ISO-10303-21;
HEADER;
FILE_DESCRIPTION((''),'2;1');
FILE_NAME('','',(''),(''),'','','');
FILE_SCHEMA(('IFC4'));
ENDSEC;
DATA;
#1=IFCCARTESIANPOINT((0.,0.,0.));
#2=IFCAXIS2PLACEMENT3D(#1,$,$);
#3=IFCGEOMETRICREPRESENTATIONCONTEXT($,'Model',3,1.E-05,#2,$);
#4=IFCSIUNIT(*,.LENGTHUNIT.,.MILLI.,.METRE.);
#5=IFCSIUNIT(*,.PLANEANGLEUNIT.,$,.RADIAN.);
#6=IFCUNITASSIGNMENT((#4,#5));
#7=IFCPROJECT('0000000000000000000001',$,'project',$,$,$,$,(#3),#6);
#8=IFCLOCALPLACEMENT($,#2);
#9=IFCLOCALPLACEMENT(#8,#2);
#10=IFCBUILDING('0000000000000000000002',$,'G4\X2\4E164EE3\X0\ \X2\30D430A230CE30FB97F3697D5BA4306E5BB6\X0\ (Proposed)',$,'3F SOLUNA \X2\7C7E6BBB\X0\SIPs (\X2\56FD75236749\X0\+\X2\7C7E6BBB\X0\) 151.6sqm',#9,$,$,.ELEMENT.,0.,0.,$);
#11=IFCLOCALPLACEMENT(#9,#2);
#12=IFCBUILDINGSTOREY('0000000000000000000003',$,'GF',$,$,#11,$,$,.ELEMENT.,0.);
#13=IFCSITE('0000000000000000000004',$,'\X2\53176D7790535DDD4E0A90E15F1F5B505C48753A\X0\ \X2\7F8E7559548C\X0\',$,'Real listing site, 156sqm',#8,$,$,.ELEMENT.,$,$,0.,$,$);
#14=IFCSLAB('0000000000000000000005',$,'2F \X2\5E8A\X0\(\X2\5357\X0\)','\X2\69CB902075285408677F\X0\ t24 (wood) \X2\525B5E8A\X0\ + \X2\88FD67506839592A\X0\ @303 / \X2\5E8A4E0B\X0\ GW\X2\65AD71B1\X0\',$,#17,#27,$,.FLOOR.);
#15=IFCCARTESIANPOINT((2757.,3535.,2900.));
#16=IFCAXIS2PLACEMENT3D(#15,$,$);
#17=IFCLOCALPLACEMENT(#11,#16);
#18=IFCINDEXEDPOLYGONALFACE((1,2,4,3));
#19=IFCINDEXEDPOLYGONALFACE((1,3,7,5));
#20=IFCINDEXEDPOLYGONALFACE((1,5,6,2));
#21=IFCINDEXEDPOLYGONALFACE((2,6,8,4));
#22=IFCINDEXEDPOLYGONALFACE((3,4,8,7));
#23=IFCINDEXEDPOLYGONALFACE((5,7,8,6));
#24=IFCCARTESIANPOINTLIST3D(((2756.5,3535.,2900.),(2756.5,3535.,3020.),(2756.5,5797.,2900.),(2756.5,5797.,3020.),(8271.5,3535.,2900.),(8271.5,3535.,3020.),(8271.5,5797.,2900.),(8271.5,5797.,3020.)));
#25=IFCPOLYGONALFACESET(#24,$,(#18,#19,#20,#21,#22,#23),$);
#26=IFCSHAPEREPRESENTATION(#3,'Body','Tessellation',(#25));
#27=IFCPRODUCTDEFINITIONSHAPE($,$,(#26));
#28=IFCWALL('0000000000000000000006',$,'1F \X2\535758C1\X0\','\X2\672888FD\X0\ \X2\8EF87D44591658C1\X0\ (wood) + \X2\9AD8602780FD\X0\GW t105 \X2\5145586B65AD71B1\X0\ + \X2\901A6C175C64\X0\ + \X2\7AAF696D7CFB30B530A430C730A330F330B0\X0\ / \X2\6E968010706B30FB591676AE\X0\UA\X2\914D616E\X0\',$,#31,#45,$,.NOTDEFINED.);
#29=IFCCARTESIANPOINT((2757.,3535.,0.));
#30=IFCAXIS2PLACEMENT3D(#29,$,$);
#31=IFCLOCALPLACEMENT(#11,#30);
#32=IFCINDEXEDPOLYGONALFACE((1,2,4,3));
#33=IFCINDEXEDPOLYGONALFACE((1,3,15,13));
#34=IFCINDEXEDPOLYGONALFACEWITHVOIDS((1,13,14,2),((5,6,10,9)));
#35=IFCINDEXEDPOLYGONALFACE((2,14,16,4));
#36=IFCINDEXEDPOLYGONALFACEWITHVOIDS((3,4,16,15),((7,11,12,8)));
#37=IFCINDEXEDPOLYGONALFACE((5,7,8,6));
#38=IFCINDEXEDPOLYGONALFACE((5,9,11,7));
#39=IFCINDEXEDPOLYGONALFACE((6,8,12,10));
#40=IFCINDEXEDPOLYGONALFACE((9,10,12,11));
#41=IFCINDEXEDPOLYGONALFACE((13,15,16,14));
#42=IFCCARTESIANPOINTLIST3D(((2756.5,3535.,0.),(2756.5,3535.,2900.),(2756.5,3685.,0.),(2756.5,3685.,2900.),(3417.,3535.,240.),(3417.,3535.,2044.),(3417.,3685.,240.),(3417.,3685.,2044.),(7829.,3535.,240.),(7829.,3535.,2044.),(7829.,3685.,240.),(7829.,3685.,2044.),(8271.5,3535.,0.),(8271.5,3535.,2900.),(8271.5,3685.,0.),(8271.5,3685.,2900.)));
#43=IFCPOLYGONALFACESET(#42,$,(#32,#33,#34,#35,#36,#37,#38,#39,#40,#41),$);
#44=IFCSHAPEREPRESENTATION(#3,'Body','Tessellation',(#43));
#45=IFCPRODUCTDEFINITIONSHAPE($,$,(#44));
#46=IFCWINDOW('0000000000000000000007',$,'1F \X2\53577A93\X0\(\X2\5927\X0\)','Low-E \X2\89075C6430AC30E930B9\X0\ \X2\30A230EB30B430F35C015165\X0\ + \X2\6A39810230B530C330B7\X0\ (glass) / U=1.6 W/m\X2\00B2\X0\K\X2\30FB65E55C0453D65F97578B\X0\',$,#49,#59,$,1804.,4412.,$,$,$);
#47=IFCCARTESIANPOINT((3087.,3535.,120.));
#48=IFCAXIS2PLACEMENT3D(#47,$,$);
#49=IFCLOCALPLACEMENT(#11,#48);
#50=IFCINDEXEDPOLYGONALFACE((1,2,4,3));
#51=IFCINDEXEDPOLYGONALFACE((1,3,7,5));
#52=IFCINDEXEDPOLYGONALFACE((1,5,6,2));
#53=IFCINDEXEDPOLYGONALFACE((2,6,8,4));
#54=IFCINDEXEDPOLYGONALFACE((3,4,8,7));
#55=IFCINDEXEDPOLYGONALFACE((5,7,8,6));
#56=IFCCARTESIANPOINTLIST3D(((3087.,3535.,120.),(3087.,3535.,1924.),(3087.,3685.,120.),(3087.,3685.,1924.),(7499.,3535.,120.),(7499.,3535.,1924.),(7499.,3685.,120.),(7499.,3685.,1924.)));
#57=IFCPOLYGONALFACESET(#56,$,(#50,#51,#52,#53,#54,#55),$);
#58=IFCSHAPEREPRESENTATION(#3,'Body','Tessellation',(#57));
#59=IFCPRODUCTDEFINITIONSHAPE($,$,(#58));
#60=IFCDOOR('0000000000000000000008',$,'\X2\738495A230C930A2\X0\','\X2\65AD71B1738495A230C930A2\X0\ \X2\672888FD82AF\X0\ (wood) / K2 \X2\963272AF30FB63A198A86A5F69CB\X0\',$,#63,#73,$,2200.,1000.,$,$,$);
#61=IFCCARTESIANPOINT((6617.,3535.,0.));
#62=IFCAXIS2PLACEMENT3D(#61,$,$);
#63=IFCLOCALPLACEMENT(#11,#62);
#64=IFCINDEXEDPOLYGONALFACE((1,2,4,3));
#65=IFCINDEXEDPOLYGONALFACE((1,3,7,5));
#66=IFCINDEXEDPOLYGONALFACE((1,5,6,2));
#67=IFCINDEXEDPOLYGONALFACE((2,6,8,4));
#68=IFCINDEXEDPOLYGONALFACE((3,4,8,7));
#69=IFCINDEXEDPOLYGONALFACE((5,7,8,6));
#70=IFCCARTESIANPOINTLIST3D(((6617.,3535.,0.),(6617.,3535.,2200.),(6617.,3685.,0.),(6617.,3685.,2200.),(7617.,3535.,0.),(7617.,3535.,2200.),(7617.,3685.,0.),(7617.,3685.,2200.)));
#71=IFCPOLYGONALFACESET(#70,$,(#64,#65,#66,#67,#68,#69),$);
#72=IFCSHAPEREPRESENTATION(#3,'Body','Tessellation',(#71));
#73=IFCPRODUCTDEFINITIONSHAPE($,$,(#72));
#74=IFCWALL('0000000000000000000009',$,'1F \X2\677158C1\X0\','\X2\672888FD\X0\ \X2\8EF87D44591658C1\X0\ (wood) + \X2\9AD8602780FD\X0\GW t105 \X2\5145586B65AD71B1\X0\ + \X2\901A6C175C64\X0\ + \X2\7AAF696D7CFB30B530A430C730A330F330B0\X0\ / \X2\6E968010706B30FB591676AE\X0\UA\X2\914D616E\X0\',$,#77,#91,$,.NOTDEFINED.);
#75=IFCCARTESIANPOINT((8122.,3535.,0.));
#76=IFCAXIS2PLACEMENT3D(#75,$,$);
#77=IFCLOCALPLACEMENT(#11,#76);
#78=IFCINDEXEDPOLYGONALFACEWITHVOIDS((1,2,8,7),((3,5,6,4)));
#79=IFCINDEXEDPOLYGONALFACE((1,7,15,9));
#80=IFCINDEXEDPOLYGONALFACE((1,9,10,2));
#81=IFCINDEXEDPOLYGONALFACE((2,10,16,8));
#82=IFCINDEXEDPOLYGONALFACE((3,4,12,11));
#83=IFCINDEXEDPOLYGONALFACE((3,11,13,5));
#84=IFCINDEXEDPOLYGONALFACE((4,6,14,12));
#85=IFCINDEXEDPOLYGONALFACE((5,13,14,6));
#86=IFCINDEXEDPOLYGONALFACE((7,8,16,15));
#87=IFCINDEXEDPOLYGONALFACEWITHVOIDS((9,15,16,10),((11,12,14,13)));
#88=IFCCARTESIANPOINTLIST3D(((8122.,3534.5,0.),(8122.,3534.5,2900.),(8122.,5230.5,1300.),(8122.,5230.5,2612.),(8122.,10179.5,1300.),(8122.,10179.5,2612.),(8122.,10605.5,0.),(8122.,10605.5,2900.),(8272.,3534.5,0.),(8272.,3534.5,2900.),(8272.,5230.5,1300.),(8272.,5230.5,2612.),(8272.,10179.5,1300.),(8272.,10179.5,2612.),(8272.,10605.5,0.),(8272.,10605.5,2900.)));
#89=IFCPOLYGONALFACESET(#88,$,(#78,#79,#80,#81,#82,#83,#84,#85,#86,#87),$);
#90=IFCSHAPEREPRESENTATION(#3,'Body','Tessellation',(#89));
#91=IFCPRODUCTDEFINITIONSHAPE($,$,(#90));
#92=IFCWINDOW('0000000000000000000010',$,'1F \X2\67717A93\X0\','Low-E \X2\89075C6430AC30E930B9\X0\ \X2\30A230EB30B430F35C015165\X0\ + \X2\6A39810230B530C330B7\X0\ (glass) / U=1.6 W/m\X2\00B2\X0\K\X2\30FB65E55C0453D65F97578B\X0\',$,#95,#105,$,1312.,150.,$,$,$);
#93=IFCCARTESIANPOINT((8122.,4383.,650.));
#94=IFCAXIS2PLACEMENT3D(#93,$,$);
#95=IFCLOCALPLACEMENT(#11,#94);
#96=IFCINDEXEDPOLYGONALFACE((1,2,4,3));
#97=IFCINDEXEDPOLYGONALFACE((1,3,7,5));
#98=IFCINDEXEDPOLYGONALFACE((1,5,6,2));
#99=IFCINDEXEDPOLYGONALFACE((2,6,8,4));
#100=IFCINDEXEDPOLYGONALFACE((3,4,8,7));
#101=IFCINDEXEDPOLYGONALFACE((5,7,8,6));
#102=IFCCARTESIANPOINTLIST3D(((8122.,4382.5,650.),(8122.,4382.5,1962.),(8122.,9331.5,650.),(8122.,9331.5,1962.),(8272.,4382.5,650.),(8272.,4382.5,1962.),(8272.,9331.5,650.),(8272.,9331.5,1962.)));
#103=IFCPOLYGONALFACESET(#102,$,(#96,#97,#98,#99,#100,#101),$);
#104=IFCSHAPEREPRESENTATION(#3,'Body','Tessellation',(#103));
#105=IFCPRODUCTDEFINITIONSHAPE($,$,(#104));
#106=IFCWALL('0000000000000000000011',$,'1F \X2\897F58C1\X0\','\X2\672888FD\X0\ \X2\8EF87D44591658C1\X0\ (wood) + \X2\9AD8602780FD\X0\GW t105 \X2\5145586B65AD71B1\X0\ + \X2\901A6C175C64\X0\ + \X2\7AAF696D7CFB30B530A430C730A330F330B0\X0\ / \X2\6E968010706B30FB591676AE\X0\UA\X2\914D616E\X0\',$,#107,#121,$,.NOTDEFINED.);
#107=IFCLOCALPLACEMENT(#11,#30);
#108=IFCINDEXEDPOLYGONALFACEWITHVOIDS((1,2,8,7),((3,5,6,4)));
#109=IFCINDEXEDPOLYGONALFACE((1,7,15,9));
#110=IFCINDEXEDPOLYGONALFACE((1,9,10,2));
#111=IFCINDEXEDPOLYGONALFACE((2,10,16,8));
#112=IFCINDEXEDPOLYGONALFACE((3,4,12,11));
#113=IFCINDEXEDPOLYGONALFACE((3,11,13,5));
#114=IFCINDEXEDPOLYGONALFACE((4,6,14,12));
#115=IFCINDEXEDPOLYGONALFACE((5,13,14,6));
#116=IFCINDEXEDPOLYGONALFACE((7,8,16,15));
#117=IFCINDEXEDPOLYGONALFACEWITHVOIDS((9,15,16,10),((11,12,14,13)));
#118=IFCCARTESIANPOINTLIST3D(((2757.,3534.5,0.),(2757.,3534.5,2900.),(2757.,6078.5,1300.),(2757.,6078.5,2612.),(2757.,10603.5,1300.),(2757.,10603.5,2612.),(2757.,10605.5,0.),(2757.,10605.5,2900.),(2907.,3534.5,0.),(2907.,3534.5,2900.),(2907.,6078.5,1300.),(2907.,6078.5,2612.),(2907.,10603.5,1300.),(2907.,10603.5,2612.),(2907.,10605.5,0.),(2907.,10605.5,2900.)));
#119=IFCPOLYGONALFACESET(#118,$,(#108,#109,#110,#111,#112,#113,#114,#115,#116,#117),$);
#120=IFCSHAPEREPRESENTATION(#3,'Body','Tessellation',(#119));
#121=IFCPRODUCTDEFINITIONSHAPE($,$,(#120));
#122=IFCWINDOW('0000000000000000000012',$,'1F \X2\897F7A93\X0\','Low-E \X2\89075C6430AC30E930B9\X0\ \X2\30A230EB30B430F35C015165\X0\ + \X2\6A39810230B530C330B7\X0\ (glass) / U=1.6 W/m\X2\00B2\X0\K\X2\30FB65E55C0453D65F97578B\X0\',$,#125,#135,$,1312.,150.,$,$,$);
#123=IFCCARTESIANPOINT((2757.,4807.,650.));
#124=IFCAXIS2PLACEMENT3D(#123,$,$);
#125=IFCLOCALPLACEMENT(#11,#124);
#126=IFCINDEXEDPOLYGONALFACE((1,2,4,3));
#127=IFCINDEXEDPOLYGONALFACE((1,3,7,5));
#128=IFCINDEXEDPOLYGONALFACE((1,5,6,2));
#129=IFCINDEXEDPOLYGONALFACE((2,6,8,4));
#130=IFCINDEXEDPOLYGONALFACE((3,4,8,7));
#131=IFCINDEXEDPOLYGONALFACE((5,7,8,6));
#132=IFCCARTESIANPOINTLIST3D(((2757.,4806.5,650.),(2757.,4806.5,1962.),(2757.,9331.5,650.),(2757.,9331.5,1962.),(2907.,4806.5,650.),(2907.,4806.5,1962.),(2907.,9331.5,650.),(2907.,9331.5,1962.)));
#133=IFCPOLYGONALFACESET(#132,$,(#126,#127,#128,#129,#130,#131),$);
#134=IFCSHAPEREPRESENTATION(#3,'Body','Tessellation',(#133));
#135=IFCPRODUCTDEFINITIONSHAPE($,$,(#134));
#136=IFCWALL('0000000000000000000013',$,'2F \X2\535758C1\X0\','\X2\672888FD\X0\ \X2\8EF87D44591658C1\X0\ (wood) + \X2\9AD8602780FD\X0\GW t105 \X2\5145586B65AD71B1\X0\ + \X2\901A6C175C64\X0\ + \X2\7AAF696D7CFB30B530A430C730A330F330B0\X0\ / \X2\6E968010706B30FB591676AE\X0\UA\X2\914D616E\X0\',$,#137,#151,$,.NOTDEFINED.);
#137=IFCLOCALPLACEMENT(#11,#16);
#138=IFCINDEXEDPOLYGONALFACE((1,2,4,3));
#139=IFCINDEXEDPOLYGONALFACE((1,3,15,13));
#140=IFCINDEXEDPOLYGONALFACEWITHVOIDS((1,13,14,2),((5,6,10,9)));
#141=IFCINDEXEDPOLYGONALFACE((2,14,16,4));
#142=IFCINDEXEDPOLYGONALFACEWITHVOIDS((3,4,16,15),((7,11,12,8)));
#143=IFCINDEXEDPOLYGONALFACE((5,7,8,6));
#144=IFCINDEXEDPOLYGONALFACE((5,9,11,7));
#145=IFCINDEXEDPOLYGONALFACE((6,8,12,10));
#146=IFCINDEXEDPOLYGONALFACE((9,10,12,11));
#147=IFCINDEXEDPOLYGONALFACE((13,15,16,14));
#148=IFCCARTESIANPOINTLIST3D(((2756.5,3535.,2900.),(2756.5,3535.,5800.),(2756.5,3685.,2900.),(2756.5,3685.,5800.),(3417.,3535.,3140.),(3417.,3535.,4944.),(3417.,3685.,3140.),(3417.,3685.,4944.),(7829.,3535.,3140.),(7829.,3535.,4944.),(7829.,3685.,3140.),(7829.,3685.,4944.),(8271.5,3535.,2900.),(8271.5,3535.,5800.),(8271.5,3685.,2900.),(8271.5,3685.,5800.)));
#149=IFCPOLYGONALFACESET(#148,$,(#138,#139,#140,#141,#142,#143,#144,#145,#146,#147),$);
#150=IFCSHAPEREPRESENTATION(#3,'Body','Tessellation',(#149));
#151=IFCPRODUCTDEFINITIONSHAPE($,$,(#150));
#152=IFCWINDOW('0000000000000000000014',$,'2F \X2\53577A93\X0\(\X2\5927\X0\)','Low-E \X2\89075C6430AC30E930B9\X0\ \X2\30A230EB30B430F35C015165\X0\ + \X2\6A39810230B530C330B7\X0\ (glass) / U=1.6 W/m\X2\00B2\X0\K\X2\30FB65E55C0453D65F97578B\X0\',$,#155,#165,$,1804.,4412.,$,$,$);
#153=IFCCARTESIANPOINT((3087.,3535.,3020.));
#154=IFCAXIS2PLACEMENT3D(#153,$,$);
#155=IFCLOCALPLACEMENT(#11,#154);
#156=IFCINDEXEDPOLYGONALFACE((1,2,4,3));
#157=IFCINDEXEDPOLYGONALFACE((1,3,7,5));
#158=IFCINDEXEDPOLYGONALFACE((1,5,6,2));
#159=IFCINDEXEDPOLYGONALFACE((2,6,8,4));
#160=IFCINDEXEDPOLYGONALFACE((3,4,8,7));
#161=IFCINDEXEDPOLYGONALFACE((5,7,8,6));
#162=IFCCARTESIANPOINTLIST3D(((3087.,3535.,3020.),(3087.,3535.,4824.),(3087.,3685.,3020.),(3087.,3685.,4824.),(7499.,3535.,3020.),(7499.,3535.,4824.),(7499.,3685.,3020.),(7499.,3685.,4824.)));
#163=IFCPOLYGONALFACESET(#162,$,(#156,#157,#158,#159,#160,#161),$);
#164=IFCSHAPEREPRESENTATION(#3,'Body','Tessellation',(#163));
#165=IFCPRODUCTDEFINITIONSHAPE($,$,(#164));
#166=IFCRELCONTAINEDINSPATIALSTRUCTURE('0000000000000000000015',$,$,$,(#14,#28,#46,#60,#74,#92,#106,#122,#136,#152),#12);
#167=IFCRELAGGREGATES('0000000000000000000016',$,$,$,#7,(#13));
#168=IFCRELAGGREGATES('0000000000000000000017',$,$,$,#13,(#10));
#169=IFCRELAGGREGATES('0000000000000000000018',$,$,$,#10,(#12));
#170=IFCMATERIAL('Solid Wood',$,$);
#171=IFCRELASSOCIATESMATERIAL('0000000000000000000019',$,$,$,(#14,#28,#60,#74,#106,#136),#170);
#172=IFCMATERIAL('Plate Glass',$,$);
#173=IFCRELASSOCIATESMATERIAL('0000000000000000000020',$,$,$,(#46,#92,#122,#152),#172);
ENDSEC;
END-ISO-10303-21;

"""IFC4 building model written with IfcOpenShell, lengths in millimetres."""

from ifc_helpers import new_model, si_unit, frame, frame_2d, origin, place, context, project, spatial, rectangle, extrude, material, element, fill, save


model = new_model("IFC4")

# Units and contexts
model_context = context("Model", 3, precision=1e-05, world=origin())
ifc_project = project(units=[si_unit("LENGTHUNIT", "METRE", prefix="MILLI"), si_unit("PLANEANGLEUNIT", "RADIAN")], contexts=[model_context])

# Site, building, storey
site_placement = place(None, origin())
site = spatial("IfcSite", under=ifc_project, at=site_placement, Name="北海道川上郡弟子屈町 美留和", ObjectType="Real listing site, 156sqm", CompositionType="ELEMENT", RefElevation=0.0)
building_placement = place(site_placement, origin())
building = spatial("IfcBuilding", under=site, at=building_placement, Name="G4世代 ピアノ・音楽室の家 (Proposed)", ObjectType="3F SOLUNA 籾殻SIPs (国産杉+籾殻) 151.6sqm", CompositionType="ELEMENT", ElevationOfRefHeight=0.0, ElevationOfTerrain=0.0)
storey_placement = place(building_placement, origin())
storey = spatial("IfcBuildingStorey", under=building, at=storey_placement, Name="GF", CompositionType="ELEMENT", Elevation=0.0)

# Slab
ifc_material_1 = material(Name="Solid Wood")
slab_1_placement = place(storey_placement, frame((2757.0, 3535.0, 2900.0)))
element("IfcSlab", 1, at=slab_1_placement, inside=storey, material=ifc_material_1, Name="2F 床(南)", Description="構造用合板 t24 (wood) 剛床 + 製材根太 @303 / 床下 GW断熱", PredefinedType="FLOOR", context=model_context, shape_type="SweptSolid", body=[
    extrude(rectangle(XDim=5515.0, YDim=2262.0, at=frame_2d((2757.0, 1131.0))), frame((2757.0, 3535.0, 2900.0)), (0.0, 0.0, 1.0), 120.0),
])

# Wall, openings, window, door
wall_1_placement = place(storey_placement, frame((2757.0, 3535.0, 0.0)))
wall_1 = element("IfcWall", 2, at=wall_1_placement, inside=storey, material=ifc_material_1, Name="1F 南壁", Description="木製 軸組外壁 (wood) + 高性能GW t105 充填断熱 + 通気層 + 窯業系サイディング / 準耐火・外皮UA配慮", PredefinedType="NOTDEFINED", context=model_context, shape_type="SweptSolid", body=[
    extrude(rectangle(XDim=5515.0, YDim=150.0, at=frame_2d((2757.0, 75.0))), frame((2757.0, 3535.0, 0.0)), (0.0, 0.0, 1.0), 2900.0),
])
opening_1_placement = place(storey_placement, frame((3087.0, 3535.0, 120.0)))
opening_1 = element("IfcOpeningElement", 3, at=opening_1_placement, cuts=wall_1, PredefinedType="NOTDEFINED", context=model_context, shape_type="SweptSolid", body=[
    extrude(rectangle(XDim=4412.0, YDim=150.0, at=frame_2d((2206.0, 75.0))), frame((3087.0, 3535.0, 120.0)), (0.0, 0.0, 1.0), 1804.0),
])
opening_2_placement = place(storey_placement, frame((6617.0, 3535.0, 0.0)))
opening_2 = element("IfcOpeningElement", 4, at=opening_2_placement, cuts=wall_1, PredefinedType="NOTDEFINED", context=model_context, shape_type="SweptSolid", body=[
    extrude(rectangle(XDim=1000.0, YDim=150.0, at=frame_2d((500.0, 75.0))), frame((6617.0, 3535.0, 0.0)), (0.0, 0.0, 1.0), 2200.0),
])
ifc_material_2 = material(Name="Plate Glass")
window_1_placement = place(storey_placement, frame((3087.0, 3535.0, 120.0)))
window_1 = element("IfcWindow", 5, at=window_1_placement, inside=storey, material=ifc_material_2, Name="1F 南窓(大)", Description="Low-E 複層ガラス アルゴン封入 + 樹脂サッシ (glass) / U=1.6 W/m²K・日射取得型", OverallHeight=1804.0, OverallWidth=4412.0, context=model_context, shape_type="SweptSolid", body=[
    extrude(rectangle(XDim=4412.0, YDim=150.0, at=frame_2d((2206.0, 75.0))), frame((3087.0, 3535.0, 120.0)), (0.0, 0.0, 1.0), 1804.0),
])
fill(opening_1, window_1)
door_placement = place(storey_placement, frame((6617.0, 3535.0, 0.0)))
door = element("IfcDoor", 6, at=door_placement, inside=storey, material=ifc_material_1, Name="玄関ドア", Description="断熱玄関ドア 木製芯 (wood) / K2 防犯・採風機構", OverallHeight=2200.0, OverallWidth=1000.0, context=model_context, shape_type="SweptSolid", body=[
    extrude(rectangle(XDim=1000.0, YDim=150.0, at=frame_2d((500.0, 75.0))), frame((6617.0, 3535.0, 0.0)), (0.0, 0.0, 1.0), 2200.0),
])
fill(opening_2, door)

# Walls, openings, windows
wall_2_placement = place(storey_placement, frame((8122.0, 3535.0, 0.0)))
wall_2 = element("IfcWall", 7, at=wall_2_placement, inside=storey, material=ifc_material_1, Name="1F 東壁", Description="木製 軸組外壁 (wood) + 高性能GW t105 充填断熱 + 通気層 + 窯業系サイディング / 準耐火・外皮UA配慮", PredefinedType="NOTDEFINED", context=model_context, shape_type="SweptSolid", body=[
    extrude(rectangle(XDim=150.0, YDim=7071.0, at=frame_2d((75.0, 3535.0))), frame((8122.0, 3535.0, 0.0)), (0.0, 0.0, 1.0), 2900.0),
])
opening_3_placement = place(storey_placement, frame((8122.0, 4383.0, 650.0)))
opening_3 = element("IfcOpeningElement", 8, at=opening_3_placement, cuts=wall_2, PredefinedType="NOTDEFINED", context=model_context, shape_type="SweptSolid", body=[
    extrude(rectangle(XDim=150.0, YDim=4949.0, at=frame_2d((75.0, 2474.0))), frame((8122.0, 4383.0, 650.0)), (0.0, 0.0, 1.0), 1312.0),
])
window_2_placement = place(storey_placement, frame((8122.0, 4383.0, 650.0)))
window_2 = element("IfcWindow", 9, at=window_2_placement, inside=storey, material=ifc_material_2, Name="1F 東窓", Description="Low-E 複層ガラス アルゴン封入 + 樹脂サッシ (glass) / U=1.6 W/m²K・日射取得型", OverallHeight=1312.0, OverallWidth=150.0, context=model_context, shape_type="SweptSolid", body=[
    extrude(rectangle(XDim=150.0, YDim=4949.0, at=frame_2d((75.0, 2474.0))), frame((8122.0, 4383.0, 650.0)), (0.0, 0.0, 1.0), 1312.0),
])
fill(opening_3, window_2)
wall_3_placement = place(storey_placement, frame((2757.0, 3535.0, 0.0)))
wall_3 = element("IfcWall", 10, at=wall_3_placement, inside=storey, material=ifc_material_1, Name="1F 西壁", Description="木製 軸組外壁 (wood) + 高性能GW t105 充填断熱 + 通気層 + 窯業系サイディング / 準耐火・外皮UA配慮", PredefinedType="NOTDEFINED", context=model_context, shape_type="SweptSolid", body=[
    extrude(rectangle(XDim=150.0, YDim=7071.0, at=frame_2d((75.0, 3535.0))), frame((2757.0, 3535.0, 0.0)), (0.0, 0.0, 1.0), 2900.0),
])
opening_4_placement = place(storey_placement, frame((2757.0, 4807.0, 650.0)))
opening_4 = element("IfcOpeningElement", 11, at=opening_4_placement, cuts=wall_3, PredefinedType="NOTDEFINED", context=model_context, shape_type="SweptSolid", body=[
    extrude(rectangle(XDim=150.0, YDim=4525.0, at=frame_2d((75.0, 2262.0))), frame((2757.0, 4807.0, 650.0)), (0.0, 0.0, 1.0), 1312.0),
])
window_3_placement = place(storey_placement, frame((2757.0, 4807.0, 650.0)))
window_3 = element("IfcWindow", 12, at=window_3_placement, inside=storey, material=ifc_material_2, Name="1F 西窓", Description="Low-E 複層ガラス アルゴン封入 + 樹脂サッシ (glass) / U=1.6 W/m²K・日射取得型", OverallHeight=1312.0, OverallWidth=150.0, context=model_context, shape_type="SweptSolid", body=[
    extrude(rectangle(XDim=150.0, YDim=4525.0, at=frame_2d((75.0, 2262.0))), frame((2757.0, 4807.0, 650.0)), (0.0, 0.0, 1.0), 1312.0),
])
fill(opening_4, window_3)
wall_4_placement = place(storey_placement, frame((2757.0, 3535.0, 2900.0)))
wall_4 = element("IfcWall", 13, at=wall_4_placement, inside=storey, material=ifc_material_1, Name="2F 南壁", Description="木製 軸組外壁 (wood) + 高性能GW t105 充填断熱 + 通気層 + 窯業系サイディング / 準耐火・外皮UA配慮", PredefinedType="NOTDEFINED", context=model_context, shape_type="SweptSolid", body=[
    extrude(rectangle(XDim=5515.0, YDim=150.0, at=frame_2d((2757.0, 75.0))), frame((2757.0, 3535.0, 2900.0)), (0.0, 0.0, 1.0), 2900.0),
])
opening_5_placement = place(storey_placement, frame((3087.0, 3535.0, 3020.0)))
opening_5 = element("IfcOpeningElement", 14, at=opening_5_placement, cuts=wall_4, PredefinedType="NOTDEFINED", context=model_context, shape_type="SweptSolid", body=[
    extrude(rectangle(XDim=4412.0, YDim=150.0, at=frame_2d((2206.0, 75.0))), frame((3087.0, 3535.0, 3020.0)), (0.0, 0.0, 1.0), 1804.0),
])
window_4_placement = place(storey_placement, frame((3087.0, 3535.0, 3020.0)))
window_4 = element("IfcWindow", 15, at=window_4_placement, inside=storey, material=ifc_material_2, Name="2F 南窓(大)", Description="Low-E 複層ガラス アルゴン封入 + 樹脂サッシ (glass) / U=1.6 W/m²K・日射取得型", OverallHeight=1804.0, OverallWidth=4412.0, context=model_context, shape_type="SweptSolid", body=[
    extrude(rectangle(XDim=4412.0, YDim=150.0, at=frame_2d((2206.0, 75.0))), frame((3087.0, 3535.0, 3020.0)), (0.0, 0.0, 1.0), 1804.0),
])
fill(opening_5, window_4)

save(model, "model.ifc")
